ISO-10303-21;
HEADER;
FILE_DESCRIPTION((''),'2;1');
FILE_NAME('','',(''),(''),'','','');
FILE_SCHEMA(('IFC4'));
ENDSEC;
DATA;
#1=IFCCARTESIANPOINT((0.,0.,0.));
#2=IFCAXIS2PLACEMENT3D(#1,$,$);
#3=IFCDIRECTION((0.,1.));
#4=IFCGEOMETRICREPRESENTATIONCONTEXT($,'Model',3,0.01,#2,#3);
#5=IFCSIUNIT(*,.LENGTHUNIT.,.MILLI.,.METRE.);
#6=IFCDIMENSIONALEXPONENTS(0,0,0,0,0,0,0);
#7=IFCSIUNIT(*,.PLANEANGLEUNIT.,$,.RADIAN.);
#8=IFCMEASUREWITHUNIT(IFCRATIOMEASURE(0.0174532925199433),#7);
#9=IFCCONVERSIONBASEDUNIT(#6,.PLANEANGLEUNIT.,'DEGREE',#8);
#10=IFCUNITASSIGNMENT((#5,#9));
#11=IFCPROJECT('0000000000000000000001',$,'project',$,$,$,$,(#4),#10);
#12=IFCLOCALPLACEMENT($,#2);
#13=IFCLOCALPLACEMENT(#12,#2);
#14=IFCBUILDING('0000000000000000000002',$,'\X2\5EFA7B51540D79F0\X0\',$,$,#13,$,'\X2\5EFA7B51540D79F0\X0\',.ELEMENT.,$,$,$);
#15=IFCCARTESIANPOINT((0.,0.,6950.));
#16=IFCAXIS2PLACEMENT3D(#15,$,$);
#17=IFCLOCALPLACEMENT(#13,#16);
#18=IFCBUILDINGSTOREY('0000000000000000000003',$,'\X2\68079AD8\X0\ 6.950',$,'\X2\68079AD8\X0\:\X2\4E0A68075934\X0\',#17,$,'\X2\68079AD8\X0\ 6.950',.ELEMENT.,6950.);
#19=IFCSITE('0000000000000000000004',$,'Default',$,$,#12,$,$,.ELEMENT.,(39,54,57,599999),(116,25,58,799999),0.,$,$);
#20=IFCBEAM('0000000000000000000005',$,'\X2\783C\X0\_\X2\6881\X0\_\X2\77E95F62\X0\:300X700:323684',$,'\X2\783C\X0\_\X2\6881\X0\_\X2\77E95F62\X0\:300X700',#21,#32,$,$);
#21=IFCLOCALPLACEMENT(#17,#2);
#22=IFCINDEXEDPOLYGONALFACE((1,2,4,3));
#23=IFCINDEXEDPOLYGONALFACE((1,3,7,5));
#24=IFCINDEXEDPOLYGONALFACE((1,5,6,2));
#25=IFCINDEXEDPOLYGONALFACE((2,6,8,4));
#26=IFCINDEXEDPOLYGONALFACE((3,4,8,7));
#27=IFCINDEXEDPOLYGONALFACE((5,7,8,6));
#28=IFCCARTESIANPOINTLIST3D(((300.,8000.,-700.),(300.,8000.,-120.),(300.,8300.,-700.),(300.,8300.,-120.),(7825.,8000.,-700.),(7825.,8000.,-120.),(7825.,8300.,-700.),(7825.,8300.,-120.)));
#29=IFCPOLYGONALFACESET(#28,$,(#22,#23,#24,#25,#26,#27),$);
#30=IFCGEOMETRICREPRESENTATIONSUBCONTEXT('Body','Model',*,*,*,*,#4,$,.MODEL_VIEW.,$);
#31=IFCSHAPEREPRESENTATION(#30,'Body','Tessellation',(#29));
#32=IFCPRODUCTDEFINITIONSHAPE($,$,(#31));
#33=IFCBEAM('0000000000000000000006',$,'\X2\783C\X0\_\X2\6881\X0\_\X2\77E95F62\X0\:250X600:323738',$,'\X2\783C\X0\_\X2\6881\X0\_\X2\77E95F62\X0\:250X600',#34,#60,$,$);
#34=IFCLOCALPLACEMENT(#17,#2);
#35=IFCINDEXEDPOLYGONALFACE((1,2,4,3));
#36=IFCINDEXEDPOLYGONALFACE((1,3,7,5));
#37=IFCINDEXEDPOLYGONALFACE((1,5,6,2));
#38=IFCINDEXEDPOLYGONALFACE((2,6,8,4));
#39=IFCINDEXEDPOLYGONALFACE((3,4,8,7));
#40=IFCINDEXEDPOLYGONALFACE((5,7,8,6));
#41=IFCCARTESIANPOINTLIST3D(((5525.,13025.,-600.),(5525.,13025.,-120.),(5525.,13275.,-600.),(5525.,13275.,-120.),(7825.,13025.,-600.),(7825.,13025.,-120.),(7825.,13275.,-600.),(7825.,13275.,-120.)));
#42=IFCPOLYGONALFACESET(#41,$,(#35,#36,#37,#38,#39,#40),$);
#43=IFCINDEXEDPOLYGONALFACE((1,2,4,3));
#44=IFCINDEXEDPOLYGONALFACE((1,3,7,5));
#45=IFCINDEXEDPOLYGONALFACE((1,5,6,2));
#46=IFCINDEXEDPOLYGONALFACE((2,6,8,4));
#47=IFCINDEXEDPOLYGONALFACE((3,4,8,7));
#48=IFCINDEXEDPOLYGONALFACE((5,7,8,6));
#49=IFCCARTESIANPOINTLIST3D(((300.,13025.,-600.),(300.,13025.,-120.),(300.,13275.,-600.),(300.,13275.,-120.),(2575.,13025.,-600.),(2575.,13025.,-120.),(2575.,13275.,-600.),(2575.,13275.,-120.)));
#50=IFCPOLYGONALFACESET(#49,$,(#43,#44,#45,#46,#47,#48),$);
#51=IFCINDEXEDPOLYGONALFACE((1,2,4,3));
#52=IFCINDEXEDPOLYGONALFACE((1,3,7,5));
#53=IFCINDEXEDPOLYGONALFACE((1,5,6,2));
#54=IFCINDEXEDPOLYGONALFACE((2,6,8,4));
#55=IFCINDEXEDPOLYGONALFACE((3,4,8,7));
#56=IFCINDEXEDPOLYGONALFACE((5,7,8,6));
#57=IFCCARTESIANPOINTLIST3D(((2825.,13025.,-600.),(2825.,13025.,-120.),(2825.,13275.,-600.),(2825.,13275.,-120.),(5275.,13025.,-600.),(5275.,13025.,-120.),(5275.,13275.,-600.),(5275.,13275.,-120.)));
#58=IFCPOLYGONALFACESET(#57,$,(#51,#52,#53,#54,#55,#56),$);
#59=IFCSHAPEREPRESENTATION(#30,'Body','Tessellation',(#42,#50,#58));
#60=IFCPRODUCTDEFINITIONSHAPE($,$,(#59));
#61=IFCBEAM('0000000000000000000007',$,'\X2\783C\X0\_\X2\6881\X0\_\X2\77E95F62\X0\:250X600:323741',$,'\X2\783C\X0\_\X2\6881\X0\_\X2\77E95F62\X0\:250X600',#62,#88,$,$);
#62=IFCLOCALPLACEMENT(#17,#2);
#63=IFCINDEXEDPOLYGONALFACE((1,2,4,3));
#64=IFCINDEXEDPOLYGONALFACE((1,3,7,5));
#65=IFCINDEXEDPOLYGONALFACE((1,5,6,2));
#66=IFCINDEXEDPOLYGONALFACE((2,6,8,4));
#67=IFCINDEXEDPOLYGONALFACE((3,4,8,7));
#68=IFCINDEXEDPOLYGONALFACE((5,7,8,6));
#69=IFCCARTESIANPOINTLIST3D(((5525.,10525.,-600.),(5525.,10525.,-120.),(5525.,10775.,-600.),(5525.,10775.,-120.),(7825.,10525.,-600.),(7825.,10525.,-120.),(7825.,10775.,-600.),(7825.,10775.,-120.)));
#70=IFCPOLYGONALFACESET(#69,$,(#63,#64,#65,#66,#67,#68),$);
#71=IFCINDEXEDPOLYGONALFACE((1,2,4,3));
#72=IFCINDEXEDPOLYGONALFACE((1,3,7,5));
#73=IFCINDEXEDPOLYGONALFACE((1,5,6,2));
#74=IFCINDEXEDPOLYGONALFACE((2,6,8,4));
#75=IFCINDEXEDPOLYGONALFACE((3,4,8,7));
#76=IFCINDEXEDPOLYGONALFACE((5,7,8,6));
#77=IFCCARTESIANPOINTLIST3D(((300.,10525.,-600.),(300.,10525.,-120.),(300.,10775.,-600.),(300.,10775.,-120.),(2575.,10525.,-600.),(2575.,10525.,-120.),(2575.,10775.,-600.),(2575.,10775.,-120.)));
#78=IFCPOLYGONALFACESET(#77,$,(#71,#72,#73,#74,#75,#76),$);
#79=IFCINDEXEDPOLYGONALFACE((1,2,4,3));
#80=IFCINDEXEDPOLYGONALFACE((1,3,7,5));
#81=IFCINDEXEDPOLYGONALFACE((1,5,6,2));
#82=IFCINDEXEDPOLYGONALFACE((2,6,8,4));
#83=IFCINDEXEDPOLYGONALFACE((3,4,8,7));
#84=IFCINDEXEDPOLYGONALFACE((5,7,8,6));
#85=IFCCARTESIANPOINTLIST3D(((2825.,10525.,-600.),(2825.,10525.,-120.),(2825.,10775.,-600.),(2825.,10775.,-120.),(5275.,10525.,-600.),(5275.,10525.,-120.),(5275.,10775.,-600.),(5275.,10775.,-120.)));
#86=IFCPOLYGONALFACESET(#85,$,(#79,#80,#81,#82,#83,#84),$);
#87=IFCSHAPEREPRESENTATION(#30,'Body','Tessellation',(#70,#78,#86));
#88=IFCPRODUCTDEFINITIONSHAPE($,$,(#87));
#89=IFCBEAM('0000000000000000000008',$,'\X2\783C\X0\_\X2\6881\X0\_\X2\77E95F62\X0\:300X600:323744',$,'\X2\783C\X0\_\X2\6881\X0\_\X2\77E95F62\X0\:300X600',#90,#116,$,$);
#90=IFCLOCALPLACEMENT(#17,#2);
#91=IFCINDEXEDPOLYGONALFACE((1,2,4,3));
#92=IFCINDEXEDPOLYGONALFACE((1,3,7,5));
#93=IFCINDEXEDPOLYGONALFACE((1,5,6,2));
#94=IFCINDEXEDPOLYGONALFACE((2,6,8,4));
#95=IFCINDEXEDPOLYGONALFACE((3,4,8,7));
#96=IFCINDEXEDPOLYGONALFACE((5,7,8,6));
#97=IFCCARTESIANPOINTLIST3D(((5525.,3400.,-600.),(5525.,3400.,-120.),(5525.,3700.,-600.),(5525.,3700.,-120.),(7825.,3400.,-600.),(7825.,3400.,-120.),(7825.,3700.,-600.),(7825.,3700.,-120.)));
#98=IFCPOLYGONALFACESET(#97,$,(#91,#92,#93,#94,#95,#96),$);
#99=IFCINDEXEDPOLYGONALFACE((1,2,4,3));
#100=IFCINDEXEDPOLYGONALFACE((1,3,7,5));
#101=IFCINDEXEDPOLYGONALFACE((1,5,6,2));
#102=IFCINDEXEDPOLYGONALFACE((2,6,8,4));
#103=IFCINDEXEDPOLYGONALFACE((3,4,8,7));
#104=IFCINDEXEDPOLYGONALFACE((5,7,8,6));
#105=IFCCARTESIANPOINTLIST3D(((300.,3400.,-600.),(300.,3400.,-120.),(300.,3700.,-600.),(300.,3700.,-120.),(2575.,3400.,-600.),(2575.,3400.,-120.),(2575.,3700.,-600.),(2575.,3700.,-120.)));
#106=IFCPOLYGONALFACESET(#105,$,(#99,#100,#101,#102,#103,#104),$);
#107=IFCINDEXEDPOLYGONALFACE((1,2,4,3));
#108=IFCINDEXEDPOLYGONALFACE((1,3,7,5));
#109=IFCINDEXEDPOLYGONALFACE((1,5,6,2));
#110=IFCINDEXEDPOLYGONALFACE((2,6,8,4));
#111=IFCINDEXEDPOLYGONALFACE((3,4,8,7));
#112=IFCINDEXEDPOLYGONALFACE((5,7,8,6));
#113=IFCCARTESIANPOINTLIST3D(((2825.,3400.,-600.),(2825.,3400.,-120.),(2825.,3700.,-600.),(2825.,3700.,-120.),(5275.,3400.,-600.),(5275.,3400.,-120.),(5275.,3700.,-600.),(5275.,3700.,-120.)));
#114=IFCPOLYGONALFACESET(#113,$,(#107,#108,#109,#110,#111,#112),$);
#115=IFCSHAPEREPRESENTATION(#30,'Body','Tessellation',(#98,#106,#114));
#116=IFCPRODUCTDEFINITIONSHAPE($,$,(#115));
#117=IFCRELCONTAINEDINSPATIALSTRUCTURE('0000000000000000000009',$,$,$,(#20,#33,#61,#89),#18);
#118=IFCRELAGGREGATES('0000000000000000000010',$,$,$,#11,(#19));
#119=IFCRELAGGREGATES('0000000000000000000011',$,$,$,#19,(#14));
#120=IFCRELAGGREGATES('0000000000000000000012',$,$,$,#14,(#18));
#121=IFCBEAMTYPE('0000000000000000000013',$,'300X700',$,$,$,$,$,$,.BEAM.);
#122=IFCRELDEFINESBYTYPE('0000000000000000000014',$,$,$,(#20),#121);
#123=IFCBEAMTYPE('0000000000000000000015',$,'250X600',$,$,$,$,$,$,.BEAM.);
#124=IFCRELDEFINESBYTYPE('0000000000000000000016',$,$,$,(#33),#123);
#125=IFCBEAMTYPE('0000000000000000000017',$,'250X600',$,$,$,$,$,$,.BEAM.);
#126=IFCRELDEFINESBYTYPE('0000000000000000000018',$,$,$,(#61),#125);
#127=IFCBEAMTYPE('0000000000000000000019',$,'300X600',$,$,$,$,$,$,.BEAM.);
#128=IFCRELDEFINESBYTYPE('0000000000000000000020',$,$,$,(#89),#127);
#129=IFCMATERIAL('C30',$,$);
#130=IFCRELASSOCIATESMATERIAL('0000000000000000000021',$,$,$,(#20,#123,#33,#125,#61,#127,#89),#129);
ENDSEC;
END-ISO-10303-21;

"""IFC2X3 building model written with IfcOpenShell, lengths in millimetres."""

from ifc_helpers import new_model, entity, si_unit, converted_unit, direction, frame, frame_2d, origin, place, context, subcontext, project, spatial, rectangle, extrude, source, transform, mapped, material, type_object, type_shapes, element, save


model = new_model("IFC2X3")

# Units and contexts
model_context = context("Model", 3, precision=0.01, world=origin(), true_north=direction((0.0, 1.0)))
body_context = subcontext(model_context, "Body", "Model", "MODEL_VIEW")
ifc_project = project(units=[si_unit("LENGTHUNIT", "METRE", prefix="MILLI"), converted_unit("PLANEANGLEUNIT", "DEGREE", entity("IfcRatioMeasure", 0.0174532925199433), si_unit("PLANEANGLEUNIT", "RADIAN"), dimensions=[0, 0, 0, 0, 0, 0, 0])], contexts=[model_context])

# Site, building, storey
site_placement = place(None, origin())
site = spatial("IfcSite", under=ifc_project, at=site_placement, Name="Default", CompositionType="ELEMENT", RefLatitude=(39, 54, 57, 599999), RefLongitude=(116, 25, 58, 799999), RefElevation=0.0)
building_placement = place(site_placement, origin())
building = spatial("IfcBuilding", under=site, at=building_placement, Name="建筑名称", LongName="建筑名称", CompositionType="ELEMENT")
storey_placement = place(building_placement, frame((0.0, 0.0, 6950.0)))
storey = spatial("IfcBuildingStorey", under=building, at=storey_placement, Name="标高 6.950", ObjectType="标高:上标头", LongName="标高 6.950", CompositionType="ELEMENT", Elevation=6950.0)

# Shared definitions
ifc_material = material(Name="C30")

# Beams
beam_type_1 = type_object("IfcBeamType", Name="300X700", PredefinedType="BEAM")
beam_1_placement = place(storey_placement, frame((0.0, 8150.0, 0.0)))
element("IfcBeam", 1, at=beam_1_placement, inside=storey, type_object=beam_type_1, material=ifc_material, Name="砼_梁_矩形:300X700:323684", ObjectType="砼_梁_矩形:300X700", context=body_context, shape_type="SweptSolid", body=[
    extrude(rectangle(XDim=580.0, YDim=300.0, at=frame_2d((0.0, 0.0), x_axis=(1.0, 0.0))), frame((300.0, 0.0, -410.0), z_axis=(1.0, 0.0, 0.0), x_axis=(0.0, 0.0, -1.0)), (0.0, 0.0, 1.0), 7525.0),
])
beam_type_2 = type_object("IfcBeamType", Name="250X600", PredefinedType="BEAM", material=ifc_material)
shared_shape_1 = source(origin(), body_context, "Body", "SweptSolid", [
    extrude(rectangle(XDim=480.0, YDim=250.0, at=frame_2d((0.0, 0.0), x_axis=(1.0, 0.0))), frame((5525.0, 13150.0, 6590.0), z_axis=(1.0, 0.0, 0.0), x_axis=(0.0, 0.0, -1.0)), (0.0, 0.0, 1.0), 2300.0),
    extrude(rectangle(XDim=480.0, YDim=250.0, at=frame_2d((0.0, 0.0), x_axis=(1.0, 0.0))), frame((300.0, 13150.0, 6590.0), z_axis=(1.0, 0.0, 0.0), x_axis=(0.0, 0.0, -1.0)), (0.0, 0.0, 1.0), 2275.0),
    extrude(rectangle(XDim=480.0, YDim=250.0, at=frame_2d((0.0, 0.0), x_axis=(1.0, 0.0))), frame((2825.0, 13150.0, 6590.0), z_axis=(1.0, 0.0, 0.0), x_axis=(0.0, 0.0, -1.0)), (0.0, 0.0, 1.0), 2450.0),
])
type_shapes(beam_type_2, [shared_shape_1])
beam_2_placement = place(storey_placement, frame((0.0, 0.0, -6950.0)))
element("IfcBeam", 2, at=beam_2_placement, inside=storey, type_object=beam_type_2, material=ifc_material, Name="砼_梁_矩形:250X600:323738", ObjectType="砼_梁_矩形:250X600", context=body_context, shape_type="MappedRepresentation", body=[
    mapped(shared_shape_1, transform((0.0, 0.0, 0.0), scale=1.0)),
])
beam_type_3 = type_object("IfcBeamType", Name="250X600", PredefinedType="BEAM", material=ifc_material)
shared_shape_2 = source(origin(), body_context, "Body", "SweptSolid", [
    extrude(rectangle(XDim=480.0, YDim=250.0, at=frame_2d((0.0, 0.0), x_axis=(1.0, 0.0))), frame((5525.0, 10650.0, 6590.0), z_axis=(1.0, 0.0, 0.0), x_axis=(0.0, 0.0, -1.0)), (0.0, 0.0, 1.0), 2300.0),
    extrude(rectangle(XDim=480.0, YDim=250.0, at=frame_2d((0.0, 0.0), x_axis=(1.0, 0.0))), frame((300.0, 10650.0, 6590.0), z_axis=(1.0, 0.0, 0.0), x_axis=(0.0, 0.0, -1.0)), (0.0, 0.0, 1.0), 2275.0),
    extrude(rectangle(XDim=480.0, YDim=250.0, at=frame_2d((0.0, 0.0), x_axis=(1.0, 0.0))), frame((2825.0, 10650.0, 6590.0), z_axis=(1.0, 0.0, 0.0), x_axis=(0.0, 0.0, -1.0)), (0.0, 0.0, 1.0), 2450.0),
])
type_shapes(beam_type_3, [shared_shape_2])
beam_3_placement = place(storey_placement, frame((0.0, 0.0, -6950.0)))
element("IfcBeam", 3, at=beam_3_placement, inside=storey, type_object=beam_type_3, material=ifc_material, Name="砼_梁_矩形:250X600:323741", ObjectType="砼_梁_矩形:250X600", context=body_context, shape_type="MappedRepresentation", body=[
    mapped(shared_shape_2, transform((0.0, 0.0, 0.0), scale=1.0)),
])
beam_type_4 = type_object("IfcBeamType", Name="300X600", PredefinedType="BEAM", material=ifc_material)
shared_shape_3 = source(origin(), body_context, "Body", "SweptSolid", [
    extrude(rectangle(XDim=480.0, YDim=300.0, at=frame_2d((0.0, 0.0), x_axis=(1.0, 0.0))), frame((5525.0, 3550.0, 6590.0), z_axis=(1.0, 0.0, 0.0), x_axis=(0.0, 0.0, -1.0)), (0.0, 0.0, 1.0), 2300.0),
    extrude(rectangle(XDim=480.0, YDim=300.0, at=frame_2d((0.0, 0.0), x_axis=(1.0, 0.0))), frame((300.0, 3550.0, 6590.0), z_axis=(1.0, 0.0, 0.0), x_axis=(0.0, 0.0, -1.0)), (0.0, 0.0, 1.0), 2275.0),
    extrude(rectangle(XDim=480.0, YDim=300.0, at=frame_2d((0.0, 0.0), x_axis=(1.0, 0.0))), frame((2825.0, 3550.0, 6590.0), z_axis=(1.0, 0.0, 0.0), x_axis=(0.0, 0.0, -1.0)), (0.0, 0.0, 1.0), 2450.0),
])
type_shapes(beam_type_4, [shared_shape_3])
beam_4_placement = place(storey_placement, frame((0.0, 0.0, -6950.0)))
element("IfcBeam", 4, at=beam_4_placement, inside=storey, type_object=beam_type_4, material=ifc_material, Name="砼_梁_矩形:300X600:323744", ObjectType="砼_梁_矩形:300X600", context=body_context, shape_type="MappedRepresentation", body=[
    mapped(shared_shape_3, transform((0.0, 0.0, 0.0), scale=1.0)),
])

save(model, "model.ifc")
